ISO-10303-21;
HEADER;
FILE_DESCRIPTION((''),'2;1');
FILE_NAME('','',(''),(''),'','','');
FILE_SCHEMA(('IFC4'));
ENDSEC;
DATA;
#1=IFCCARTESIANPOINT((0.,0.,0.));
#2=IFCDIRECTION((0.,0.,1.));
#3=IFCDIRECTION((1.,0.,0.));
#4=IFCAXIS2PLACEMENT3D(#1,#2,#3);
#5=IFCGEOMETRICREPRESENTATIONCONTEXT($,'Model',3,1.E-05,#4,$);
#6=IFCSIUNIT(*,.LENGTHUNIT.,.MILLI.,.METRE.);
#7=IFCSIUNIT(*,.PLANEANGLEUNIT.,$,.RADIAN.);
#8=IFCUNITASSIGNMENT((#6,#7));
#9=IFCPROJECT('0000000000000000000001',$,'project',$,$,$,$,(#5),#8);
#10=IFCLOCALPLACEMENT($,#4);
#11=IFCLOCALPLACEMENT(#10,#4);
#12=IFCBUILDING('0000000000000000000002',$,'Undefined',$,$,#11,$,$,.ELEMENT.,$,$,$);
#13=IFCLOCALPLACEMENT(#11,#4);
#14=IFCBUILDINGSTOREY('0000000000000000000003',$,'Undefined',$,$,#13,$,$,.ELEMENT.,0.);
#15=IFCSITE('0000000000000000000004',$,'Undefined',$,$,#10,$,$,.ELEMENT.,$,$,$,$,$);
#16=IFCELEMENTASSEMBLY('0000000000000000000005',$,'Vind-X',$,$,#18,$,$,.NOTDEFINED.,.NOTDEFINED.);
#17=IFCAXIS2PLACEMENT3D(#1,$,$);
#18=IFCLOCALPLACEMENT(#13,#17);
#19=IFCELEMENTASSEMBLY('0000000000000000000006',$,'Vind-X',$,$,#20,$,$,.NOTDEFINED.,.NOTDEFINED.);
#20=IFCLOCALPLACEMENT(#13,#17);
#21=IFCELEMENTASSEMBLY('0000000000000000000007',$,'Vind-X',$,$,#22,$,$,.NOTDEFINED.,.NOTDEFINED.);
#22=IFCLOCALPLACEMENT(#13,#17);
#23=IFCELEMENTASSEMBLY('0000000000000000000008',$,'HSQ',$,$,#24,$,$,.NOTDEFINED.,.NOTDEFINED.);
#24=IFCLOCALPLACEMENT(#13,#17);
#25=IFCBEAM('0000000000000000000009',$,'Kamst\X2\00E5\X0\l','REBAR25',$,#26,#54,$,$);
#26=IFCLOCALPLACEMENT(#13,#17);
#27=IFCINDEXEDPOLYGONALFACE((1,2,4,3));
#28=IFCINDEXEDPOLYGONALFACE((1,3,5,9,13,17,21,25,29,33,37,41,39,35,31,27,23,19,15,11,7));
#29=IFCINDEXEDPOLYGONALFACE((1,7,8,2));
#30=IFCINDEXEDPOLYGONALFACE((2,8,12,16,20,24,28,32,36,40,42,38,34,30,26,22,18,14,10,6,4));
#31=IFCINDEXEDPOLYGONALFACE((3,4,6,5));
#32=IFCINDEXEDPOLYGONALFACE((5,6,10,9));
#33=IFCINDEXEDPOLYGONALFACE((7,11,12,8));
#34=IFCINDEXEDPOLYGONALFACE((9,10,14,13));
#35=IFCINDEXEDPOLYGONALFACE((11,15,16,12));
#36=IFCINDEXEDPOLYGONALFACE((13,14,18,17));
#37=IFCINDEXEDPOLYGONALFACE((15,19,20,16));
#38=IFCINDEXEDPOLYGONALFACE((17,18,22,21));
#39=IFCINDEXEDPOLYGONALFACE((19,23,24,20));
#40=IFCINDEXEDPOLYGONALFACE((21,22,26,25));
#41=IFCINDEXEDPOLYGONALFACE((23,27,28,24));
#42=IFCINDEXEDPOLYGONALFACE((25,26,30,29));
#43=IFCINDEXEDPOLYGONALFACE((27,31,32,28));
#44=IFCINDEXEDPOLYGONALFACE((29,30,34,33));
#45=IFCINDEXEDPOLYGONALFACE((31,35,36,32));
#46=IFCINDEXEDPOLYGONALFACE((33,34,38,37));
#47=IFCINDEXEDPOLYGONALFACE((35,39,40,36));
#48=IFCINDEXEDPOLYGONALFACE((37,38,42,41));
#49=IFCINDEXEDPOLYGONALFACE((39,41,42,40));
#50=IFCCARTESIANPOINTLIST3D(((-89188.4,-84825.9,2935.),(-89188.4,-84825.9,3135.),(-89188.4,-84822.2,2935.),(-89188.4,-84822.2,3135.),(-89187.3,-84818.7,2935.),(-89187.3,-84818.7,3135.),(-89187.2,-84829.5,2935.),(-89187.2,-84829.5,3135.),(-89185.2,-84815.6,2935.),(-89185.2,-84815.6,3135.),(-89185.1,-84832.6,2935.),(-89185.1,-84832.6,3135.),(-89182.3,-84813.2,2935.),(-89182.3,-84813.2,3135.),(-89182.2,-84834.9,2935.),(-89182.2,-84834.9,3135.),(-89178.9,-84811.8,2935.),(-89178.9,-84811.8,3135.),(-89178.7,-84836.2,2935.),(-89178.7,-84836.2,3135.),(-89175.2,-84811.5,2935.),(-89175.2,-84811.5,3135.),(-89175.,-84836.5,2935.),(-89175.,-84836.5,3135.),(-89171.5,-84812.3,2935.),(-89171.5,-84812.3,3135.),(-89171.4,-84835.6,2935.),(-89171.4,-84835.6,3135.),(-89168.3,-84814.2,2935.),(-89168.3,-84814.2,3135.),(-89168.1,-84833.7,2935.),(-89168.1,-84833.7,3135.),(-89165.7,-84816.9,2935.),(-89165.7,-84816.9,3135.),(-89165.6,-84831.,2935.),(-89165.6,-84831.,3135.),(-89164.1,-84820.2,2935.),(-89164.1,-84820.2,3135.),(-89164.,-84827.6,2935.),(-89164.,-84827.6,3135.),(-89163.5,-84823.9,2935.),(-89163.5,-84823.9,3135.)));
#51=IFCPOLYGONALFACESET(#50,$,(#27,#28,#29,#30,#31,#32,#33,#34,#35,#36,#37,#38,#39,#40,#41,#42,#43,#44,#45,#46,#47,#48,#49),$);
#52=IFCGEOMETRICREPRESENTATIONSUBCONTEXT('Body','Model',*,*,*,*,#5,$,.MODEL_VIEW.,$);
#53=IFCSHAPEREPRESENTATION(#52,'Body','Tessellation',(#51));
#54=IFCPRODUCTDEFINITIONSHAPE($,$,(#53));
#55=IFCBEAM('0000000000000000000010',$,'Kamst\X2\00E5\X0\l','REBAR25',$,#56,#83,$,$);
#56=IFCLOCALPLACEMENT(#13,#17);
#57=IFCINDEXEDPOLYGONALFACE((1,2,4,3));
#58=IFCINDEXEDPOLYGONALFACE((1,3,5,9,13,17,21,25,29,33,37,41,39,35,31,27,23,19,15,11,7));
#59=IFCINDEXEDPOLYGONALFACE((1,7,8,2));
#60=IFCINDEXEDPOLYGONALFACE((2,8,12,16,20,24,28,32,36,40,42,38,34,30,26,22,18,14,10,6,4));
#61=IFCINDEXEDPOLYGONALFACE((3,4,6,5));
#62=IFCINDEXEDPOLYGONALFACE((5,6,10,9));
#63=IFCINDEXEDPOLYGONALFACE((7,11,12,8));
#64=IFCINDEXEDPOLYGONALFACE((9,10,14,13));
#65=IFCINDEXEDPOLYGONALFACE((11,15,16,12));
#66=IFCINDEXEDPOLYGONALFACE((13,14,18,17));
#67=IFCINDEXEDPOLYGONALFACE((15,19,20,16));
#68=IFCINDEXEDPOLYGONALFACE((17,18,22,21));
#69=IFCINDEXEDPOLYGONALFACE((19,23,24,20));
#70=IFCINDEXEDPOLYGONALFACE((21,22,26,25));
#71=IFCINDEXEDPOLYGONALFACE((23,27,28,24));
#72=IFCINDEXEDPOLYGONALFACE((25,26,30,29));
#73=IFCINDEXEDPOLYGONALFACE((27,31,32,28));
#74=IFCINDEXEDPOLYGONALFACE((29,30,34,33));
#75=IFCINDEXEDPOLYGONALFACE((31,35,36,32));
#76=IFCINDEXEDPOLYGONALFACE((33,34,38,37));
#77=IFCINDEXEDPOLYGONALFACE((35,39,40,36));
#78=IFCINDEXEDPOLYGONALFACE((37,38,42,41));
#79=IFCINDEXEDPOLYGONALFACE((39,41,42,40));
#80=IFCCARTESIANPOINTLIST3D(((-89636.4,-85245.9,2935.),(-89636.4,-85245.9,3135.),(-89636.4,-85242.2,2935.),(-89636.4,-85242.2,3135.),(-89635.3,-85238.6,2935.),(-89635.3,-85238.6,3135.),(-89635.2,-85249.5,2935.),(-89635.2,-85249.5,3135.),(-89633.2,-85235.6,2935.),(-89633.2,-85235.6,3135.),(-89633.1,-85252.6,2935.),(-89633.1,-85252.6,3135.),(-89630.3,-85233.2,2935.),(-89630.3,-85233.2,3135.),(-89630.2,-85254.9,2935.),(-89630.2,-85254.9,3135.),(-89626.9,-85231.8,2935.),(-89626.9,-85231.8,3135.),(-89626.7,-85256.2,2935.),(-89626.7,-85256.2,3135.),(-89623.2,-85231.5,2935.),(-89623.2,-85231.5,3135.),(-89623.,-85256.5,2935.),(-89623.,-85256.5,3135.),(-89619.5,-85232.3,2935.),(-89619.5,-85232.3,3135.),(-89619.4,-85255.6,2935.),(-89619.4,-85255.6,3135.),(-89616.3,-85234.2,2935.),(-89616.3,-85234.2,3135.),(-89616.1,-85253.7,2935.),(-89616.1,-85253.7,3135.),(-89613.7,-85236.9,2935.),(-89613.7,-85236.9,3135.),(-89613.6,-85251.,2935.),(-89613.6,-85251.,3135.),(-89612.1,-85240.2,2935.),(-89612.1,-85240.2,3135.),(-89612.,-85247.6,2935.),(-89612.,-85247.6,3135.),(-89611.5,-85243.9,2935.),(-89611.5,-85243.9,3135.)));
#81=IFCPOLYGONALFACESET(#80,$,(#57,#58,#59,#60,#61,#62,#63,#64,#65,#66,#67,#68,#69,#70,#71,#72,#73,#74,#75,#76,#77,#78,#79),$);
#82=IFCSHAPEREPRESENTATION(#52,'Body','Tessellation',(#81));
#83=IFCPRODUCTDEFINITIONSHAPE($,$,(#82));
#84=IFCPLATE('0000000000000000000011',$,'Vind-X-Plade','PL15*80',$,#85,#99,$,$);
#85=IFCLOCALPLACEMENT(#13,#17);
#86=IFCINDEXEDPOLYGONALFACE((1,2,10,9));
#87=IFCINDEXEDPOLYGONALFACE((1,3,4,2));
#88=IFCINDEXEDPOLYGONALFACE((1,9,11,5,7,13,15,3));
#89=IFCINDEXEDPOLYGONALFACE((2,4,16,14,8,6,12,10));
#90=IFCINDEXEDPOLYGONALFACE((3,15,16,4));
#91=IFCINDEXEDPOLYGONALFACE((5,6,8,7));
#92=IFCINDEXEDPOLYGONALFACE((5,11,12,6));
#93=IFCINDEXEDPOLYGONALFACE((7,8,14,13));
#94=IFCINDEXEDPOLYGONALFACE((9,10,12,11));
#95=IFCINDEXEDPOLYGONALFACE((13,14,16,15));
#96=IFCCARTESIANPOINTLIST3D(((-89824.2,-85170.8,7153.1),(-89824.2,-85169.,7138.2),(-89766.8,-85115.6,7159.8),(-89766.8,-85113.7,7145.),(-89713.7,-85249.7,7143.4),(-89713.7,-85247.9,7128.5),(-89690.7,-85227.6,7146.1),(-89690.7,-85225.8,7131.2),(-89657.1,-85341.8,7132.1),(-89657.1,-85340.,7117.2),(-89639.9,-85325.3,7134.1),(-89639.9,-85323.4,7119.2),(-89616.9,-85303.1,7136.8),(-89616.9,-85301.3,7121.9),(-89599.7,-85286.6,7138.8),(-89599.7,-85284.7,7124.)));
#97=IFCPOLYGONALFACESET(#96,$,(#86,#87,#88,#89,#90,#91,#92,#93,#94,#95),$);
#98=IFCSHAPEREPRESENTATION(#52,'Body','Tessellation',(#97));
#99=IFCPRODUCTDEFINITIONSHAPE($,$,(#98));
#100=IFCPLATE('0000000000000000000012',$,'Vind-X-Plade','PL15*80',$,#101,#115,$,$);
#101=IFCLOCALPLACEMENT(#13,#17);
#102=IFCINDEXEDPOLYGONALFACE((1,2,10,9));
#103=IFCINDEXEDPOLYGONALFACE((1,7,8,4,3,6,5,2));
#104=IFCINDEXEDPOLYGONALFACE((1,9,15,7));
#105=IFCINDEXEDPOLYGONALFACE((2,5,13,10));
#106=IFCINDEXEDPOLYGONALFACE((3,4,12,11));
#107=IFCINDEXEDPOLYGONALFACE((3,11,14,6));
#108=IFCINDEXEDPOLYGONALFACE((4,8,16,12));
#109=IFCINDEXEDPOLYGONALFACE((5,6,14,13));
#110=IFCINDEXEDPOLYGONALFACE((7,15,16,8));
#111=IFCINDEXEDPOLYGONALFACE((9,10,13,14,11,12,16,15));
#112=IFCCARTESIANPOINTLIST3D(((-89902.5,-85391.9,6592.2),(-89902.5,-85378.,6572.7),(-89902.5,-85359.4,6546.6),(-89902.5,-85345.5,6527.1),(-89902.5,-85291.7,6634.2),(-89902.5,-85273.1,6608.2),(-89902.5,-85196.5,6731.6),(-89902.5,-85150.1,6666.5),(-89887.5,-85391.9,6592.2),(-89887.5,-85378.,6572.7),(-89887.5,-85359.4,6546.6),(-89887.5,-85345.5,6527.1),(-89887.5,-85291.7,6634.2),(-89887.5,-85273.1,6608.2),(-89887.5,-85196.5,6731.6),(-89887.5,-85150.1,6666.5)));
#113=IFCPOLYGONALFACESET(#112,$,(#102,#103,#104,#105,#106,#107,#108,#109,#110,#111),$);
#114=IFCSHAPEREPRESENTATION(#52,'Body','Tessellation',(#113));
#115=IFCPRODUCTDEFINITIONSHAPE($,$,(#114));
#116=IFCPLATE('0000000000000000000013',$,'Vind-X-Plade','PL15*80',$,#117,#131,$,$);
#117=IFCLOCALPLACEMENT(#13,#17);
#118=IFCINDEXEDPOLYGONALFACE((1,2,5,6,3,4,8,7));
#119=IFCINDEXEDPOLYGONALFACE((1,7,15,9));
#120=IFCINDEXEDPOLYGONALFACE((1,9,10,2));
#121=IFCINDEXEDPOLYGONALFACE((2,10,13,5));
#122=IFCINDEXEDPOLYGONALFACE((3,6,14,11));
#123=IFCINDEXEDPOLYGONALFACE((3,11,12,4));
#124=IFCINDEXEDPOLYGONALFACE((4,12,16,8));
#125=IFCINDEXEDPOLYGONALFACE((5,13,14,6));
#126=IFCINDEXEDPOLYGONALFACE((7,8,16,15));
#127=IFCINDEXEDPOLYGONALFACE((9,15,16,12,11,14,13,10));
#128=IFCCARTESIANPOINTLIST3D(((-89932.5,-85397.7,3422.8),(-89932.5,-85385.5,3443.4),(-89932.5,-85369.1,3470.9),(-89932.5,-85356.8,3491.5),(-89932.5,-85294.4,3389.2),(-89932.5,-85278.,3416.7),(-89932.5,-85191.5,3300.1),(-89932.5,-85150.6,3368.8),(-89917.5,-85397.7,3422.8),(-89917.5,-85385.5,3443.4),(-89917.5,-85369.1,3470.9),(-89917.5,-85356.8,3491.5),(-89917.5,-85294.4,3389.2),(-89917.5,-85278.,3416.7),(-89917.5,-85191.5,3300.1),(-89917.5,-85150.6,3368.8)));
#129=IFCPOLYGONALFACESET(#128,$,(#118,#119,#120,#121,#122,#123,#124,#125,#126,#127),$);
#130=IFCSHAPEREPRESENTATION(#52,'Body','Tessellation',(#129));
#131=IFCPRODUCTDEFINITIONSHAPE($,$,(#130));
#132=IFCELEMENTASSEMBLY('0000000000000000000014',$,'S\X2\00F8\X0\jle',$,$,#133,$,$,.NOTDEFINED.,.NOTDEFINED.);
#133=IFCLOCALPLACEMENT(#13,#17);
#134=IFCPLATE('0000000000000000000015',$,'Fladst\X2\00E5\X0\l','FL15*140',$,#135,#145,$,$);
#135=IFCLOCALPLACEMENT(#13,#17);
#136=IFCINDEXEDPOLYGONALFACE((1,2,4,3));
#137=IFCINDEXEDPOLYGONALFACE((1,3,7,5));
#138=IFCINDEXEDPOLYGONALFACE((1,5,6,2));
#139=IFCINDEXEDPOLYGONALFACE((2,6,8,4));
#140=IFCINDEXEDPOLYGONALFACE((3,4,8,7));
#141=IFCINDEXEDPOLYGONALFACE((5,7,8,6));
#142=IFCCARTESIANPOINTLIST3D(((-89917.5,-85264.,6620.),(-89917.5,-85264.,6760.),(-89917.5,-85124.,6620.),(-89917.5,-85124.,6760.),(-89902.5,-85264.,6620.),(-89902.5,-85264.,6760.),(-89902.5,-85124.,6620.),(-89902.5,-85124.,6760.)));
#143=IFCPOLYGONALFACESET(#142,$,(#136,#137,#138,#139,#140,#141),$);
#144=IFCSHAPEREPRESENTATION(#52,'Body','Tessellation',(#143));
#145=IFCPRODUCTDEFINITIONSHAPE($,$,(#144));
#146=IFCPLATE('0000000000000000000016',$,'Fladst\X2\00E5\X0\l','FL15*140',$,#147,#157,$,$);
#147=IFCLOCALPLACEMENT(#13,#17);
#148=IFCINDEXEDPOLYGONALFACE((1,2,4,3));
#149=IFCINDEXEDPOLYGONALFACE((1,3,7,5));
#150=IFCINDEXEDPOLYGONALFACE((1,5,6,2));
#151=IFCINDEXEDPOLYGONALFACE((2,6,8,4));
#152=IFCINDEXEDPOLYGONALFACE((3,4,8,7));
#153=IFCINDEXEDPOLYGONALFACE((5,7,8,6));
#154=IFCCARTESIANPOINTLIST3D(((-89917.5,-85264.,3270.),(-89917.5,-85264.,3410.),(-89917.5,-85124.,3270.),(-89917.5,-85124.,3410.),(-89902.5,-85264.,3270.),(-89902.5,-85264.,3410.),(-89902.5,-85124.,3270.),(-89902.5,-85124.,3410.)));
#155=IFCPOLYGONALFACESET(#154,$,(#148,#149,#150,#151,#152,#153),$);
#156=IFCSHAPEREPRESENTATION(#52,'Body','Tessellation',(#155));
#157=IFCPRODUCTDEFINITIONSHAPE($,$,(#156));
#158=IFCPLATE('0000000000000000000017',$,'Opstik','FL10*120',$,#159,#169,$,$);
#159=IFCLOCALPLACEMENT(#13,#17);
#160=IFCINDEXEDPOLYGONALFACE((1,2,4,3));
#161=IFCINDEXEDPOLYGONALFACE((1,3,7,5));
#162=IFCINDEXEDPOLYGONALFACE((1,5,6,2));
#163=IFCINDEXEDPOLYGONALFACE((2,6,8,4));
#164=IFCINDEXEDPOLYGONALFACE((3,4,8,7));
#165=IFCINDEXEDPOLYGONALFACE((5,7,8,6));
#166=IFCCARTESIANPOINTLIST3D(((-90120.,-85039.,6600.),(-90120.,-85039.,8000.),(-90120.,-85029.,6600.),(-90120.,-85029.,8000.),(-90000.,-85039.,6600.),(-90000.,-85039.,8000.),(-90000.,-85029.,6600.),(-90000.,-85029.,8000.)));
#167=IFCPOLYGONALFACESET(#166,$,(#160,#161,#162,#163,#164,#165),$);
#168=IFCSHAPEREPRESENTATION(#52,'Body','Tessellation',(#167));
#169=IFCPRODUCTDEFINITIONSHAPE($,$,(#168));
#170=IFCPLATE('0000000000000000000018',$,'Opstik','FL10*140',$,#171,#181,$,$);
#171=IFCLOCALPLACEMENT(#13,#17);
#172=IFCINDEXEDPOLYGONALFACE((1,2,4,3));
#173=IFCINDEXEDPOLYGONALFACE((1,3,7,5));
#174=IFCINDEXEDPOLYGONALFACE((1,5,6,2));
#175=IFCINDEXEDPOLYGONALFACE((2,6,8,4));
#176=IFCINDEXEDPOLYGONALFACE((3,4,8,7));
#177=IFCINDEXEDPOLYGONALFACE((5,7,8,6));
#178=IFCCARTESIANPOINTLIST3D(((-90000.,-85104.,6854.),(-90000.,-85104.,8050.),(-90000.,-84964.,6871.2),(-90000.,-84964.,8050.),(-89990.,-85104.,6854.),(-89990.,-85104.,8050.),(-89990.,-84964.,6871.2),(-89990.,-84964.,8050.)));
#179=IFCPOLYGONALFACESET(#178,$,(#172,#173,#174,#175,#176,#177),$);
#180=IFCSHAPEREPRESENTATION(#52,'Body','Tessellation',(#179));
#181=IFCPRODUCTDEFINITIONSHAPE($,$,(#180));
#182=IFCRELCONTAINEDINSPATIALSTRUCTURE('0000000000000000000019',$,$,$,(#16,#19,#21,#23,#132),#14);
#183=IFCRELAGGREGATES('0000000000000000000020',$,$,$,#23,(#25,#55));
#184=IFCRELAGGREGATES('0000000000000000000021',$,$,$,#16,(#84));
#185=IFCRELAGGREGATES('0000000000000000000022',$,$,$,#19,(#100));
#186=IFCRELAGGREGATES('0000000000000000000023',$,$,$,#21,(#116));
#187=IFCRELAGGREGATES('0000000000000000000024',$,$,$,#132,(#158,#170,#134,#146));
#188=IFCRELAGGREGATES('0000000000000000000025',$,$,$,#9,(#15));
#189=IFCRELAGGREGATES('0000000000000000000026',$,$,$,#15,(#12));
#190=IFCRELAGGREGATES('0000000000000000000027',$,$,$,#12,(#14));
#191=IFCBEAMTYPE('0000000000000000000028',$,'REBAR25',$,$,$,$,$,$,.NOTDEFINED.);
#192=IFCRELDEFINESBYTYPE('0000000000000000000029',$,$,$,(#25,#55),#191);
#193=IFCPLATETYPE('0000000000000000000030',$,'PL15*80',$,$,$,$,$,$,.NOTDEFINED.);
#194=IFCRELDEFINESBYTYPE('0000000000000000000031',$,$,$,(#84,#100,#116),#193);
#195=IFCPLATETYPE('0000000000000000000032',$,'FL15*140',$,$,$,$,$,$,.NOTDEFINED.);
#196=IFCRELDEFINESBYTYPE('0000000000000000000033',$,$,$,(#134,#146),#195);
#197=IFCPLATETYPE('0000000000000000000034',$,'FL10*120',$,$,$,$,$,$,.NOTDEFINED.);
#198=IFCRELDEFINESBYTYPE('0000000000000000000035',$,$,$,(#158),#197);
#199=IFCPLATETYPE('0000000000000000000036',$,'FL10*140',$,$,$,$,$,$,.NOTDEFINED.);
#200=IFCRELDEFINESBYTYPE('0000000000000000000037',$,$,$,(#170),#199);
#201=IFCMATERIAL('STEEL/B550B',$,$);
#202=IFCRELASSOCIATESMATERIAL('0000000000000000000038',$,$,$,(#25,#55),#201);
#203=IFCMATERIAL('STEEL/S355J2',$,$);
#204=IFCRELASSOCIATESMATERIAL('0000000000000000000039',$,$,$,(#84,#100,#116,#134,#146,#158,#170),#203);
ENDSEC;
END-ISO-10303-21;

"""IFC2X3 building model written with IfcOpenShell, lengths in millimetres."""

from ifc_helpers import new_model, si_unit, frame, origin_with_axes, origin_2d_with_axis, place, context, subcontext, project, spatial, polyline, circle, outline, extrude, boolean, material, type_object, element, aggregate, save


model = new_model("IFC2X3")

# Units and contexts
model_context = context("Model", 3, precision=1e-05, world=origin_with_axes())
body_context = subcontext(model_context, "Body", "Model", "MODEL_VIEW")
ifc_project = project(units=[si_unit("LENGTHUNIT", "METRE", prefix="MILLI"), si_unit("PLANEANGLEUNIT", "RADIAN")], contexts=[model_context])

# Site, building, storey
site_placement = place(None, origin_with_axes())
site = spatial("IfcSite", under=ifc_project, at=site_placement, Name="Undefined", CompositionType="ELEMENT")
building_placement = place(site_placement, origin_with_axes())
building = spatial("IfcBuilding", under=site, at=building_placement, Name="Undefined", CompositionType="ELEMENT")
storey_placement = place(building_placement, origin_with_axes())
storey = spatial("IfcBuildingStorey", under=building, at=storey_placement, Name="Undefined", CompositionType="ELEMENT", Elevation=0.0)

# Shared definitions
ifc_material_1 = material(Name="STEEL/S355J2")

# Element assembly
assembly_1_placement = place(storey_placement, origin_with_axes())
assembly_1 = element("IfcElementAssembly", 1, at=assembly_1_placement, inside=storey, Name="Vind-X", AssemblyPlace="NOTDEFINED", PredefinedType="NOTDEFINED")

# Element assemblies
assembly_2_placement = place(storey_placement, origin_with_axes())
assembly_2 = element("IfcElementAssembly", 2, at=assembly_2_placement, inside=storey, Name="Vind-X", AssemblyPlace="NOTDEFINED", PredefinedType="NOTDEFINED")
assembly_3_placement = place(storey_placement, origin_with_axes())
assembly_3 = element("IfcElementAssembly", 3, at=assembly_3_placement, inside=storey, Name="Vind-X", AssemblyPlace="NOTDEFINED", PredefinedType="NOTDEFINED")

# Element assembly, beams
assembly_4_placement = place(storey_placement, origin_with_axes())
assembly_4 = element("IfcElementAssembly", 4, at=assembly_4_placement, inside=storey, Name="HSQ", AssemblyPlace="NOTDEFINED", PredefinedType="NOTDEFINED")
ifc_material_2 = material(Name="STEEL/B550B")
beam_type_1 = type_object("IfcBeamType", Name="REBAR25", PredefinedType="NOTDEFINED")
beam_1_placement = place(assembly_4_placement, frame((-89176.0, -84824.0, 3135.0), z_axis=(-0.862746, -0.505638, 0.0), x_axis=(0.0, 0.0, -1.0)))
beam_1 = element("IfcBeam", 5, at=beam_1_placement, type_object=beam_type_1, material=ifc_material_2, Name="Kamstål", Description="REBAR25", context=body_context, shape_type="SweptSolid", body=[
    extrude(circle(Radius=12.5, at=origin_2d_with_axis()), frame((200.0, 0.0, 0.0), z_axis=(-1.0, 0.0, 0.0), x_axis=(0.0, -1.0, 0.0)), (0.0, 0.0, 1.0), 200.0),
])
beam_2_placement = place(assembly_4_placement, frame((-89624.0, -85244.0, 3135.0), z_axis=(-0.862746, -0.505638, 0.0), x_axis=(0.0, 0.0, -1.0)))
beam_2 = element("IfcBeam", 6, at=beam_2_placement, type_object=beam_type_1, material=ifc_material_2, Name="Kamstål", Description="REBAR25", context=body_context, shape_type="SweptSolid", body=[
    extrude(circle(Radius=12.5, at=origin_2d_with_axis()), frame((200.0, 0.0, 0.0), z_axis=(-1.0, 0.0, 0.0), x_axis=(0.0, -1.0, 0.0)), (0.0, 0.0, 1.0), 200.0),
])

# Plates
plate_type_1 = type_object("IfcPlateType", Name="PL15*80", PredefinedType="NOTDEFINED")
plate_1_placement = place(assembly_1_placement, frame((-89824.2, -85169.9, 7145.6), z_axis=(0.0, 0.121869, -0.992546), x_axis=(0.717842, 0.691017, 0.084846)))
plate_1 = element("IfcPlate", 7, at=plate_1_placement, type_object=plate_type_1, material=ifc_material_1, Name="Vind-X-Plade", Description="PL15*80", context=body_context, shape_type="CSG", body=[
    boolean("DIFFERENCE", extrude(outline(polyline([(0.0, 0.0), (80.0, 0.0), (80.0, 240.0), (0.0, 240.0), (0.0, 0.0)])), frame((0.0, 0.0, -7.5), z_axis=(0.0, 0.0, 1.0), x_axis=(1.0, 0.0, 0.0)), (0.0, 0.0, 1.0), 15.0), extrude(outline(polyline([(0.0, 0.0), (106.0, 0.0), (106.0, 32.0), (0.0, 32.0), (0.0, 0.0)])), frame((56.0, 240.0, 8.5), z_axis=(0.0, 0.0, -1.0), x_axis=(0.0, -1.0, 0.0)), (0.0, 0.0, 1.0), 17.0)),
])
plate_2_placement = place(assembly_2_placement, frame((-89895.0, -85150.1, 6666.5), z_axis=(1.0, 0.0, 0.0), x_axis=(0.0, -0.58074, 0.814089)))
plate_2 = element("IfcPlate", 8, at=plate_2_placement, type_object=plate_type_1, material=ifc_material_1, Name="Vind-X-Plade", Description="PL15*80", context=body_context, shape_type="CSG", body=[
    boolean("DIFFERENCE", extrude(outline(polyline([(0.0, 0.0), (80.0, 0.0), (80.0, 240.0), (0.0, 240.0), (0.0, 0.0)])), frame((0.0, 0.0, -7.5), z_axis=(0.0, 0.0, 1.0), x_axis=(1.0, 0.0, 0.0)), (0.0, 0.0, 1.0), 15.0), extrude(outline(polyline([(0.0, 0.0), (106.0, 0.0), (106.0, 32.0), (0.0, 32.0), (0.0, 0.0)])), frame((56.0, 240.0, 8.5), z_axis=(0.0, 0.0, -1.0), x_axis=(0.0, -1.0, 0.0)), (0.0, 0.0, 1.0), 17.0)),
])
plate_3_placement = place(assembly_3_placement, frame((-89925.0, -85191.5, 3300.1), z_axis=(1.0, 0.0, 0.0), x_axis=(0.0, 0.511223, 0.859448)))
plate_3 = element("IfcPlate", 9, at=plate_3_placement, type_object=plate_type_1, material=ifc_material_1, Name="Vind-X-Plade", Description="PL15*80", context=body_context, shape_type="CSG", body=[
    boolean("DIFFERENCE", extrude(outline(polyline([(0.0, 0.0), (80.0, 0.0), (80.0, 240.0), (0.0, 240.0), (0.0, 0.0)])), frame((0.0, 0.0, -7.5), z_axis=(0.0, 0.0, 1.0), x_axis=(1.0, 0.0, 0.0)), (0.0, 0.0, 1.0), 15.0), extrude(outline(polyline([(0.0, 0.0), (106.0, 0.0), (106.0, 32.0), (0.0, 32.0), (0.0, 0.0)])), frame((56.0, 240.0, 8.5), z_axis=(0.0, 0.0, -1.0), x_axis=(0.0, -1.0, 0.0)), (0.0, 0.0, 1.0), 17.0)),
])

# Element assembly, plates
assembly_5_placement = place(storey_placement, origin_with_axes())
assembly_5 = element("IfcElementAssembly", 10, at=assembly_5_placement, inside=storey, Name="Søjle", AssemblyPlace="NOTDEFINED", PredefinedType="NOTDEFINED")
plate_type_2 = type_object("IfcPlateType", Name="FL15*140", PredefinedType="NOTDEFINED")
plate_4_placement = place(assembly_5_placement, frame((-89910.0, -85124.0, 6620.0), z_axis=(-1.0, -0.000008, 0.0), x_axis=(0.000008, -1.0, 0.0)))
plate_4 = element("IfcPlate", 11, at=plate_4_placement, type_object=plate_type_2, material=ifc_material_1, Name="Fladstål", Description="FL15*140", context=body_context, shape_type="SweptSolid", body=[
    extrude(outline(polyline([(0.0, 0.0), (140.0, 0.0), (140.0, 140.0), (0.0, 140.0), (0.0, 0.0)])), frame((0.0, 0.0, -7.5), z_axis=(0.0, 0.0, 1.0), x_axis=(1.0, 0.0, 0.0)), (0.0, 0.0, 1.0), 15.0),
])
plate_5_placement = place(assembly_5_placement, frame((-89910.0, -85124.0, 3270.0), z_axis=(-1.0, -0.000008, 0.0), x_axis=(0.000008, -1.0, 0.0)))
plate_5 = element("IfcPlate", 12, at=plate_5_placement, type_object=plate_type_2, material=ifc_material_1, Name="Fladstål", Description="FL15*140", context=body_context, shape_type="SweptSolid", body=[
    extrude(outline(polyline([(0.0, 0.0), (140.0, 0.0), (140.0, 140.0), (0.0, 140.0), (0.0, 0.0)])), frame((0.0, 0.0, -7.5), z_axis=(0.0, 0.0, 1.0), x_axis=(1.0, 0.0, 0.0)), (0.0, 0.0, 1.0), 15.0),
])
plate_type_3 = type_object("IfcPlateType", Name="FL10*120", PredefinedType="NOTDEFINED")
plate_6_placement = place(assembly_5_placement, frame((-90000.0, -85034.0, 6600.0), z_axis=(0.0, -1.0, 0.0), x_axis=(0.0, 0.0, 1.0)))
plate_6 = element("IfcPlate", 13, at=plate_6_placement, type_object=plate_type_3, material=ifc_material_1, Name="Opstik", Description="FL10*120", context=body_context, shape_type="SweptSolid", body=[
    extrude(outline(polyline([(0.0, 0.0), (1400.0, 0.0), (1400.0, 120.0), (1400.0, 120.0), (0.0, 120.0), (0.0, 120.0), (0.0, 0.0)])), frame((0.0, 0.0, -5.0), z_axis=(0.0, 0.0, 1.0), x_axis=(1.0, 0.0, 0.0)), (0.0, 0.0, 1.0), 10.0),
])
plate_type_4 = type_object("IfcPlateType", Name="FL10*140", PredefinedType="NOTDEFINED")
plate_7_placement = place(assembly_5_placement, frame((-89995.0, -85104.0, 6854.0), z_axis=(-1.0, 0.0, 0.0), x_axis=(0.0, 0.0, 1.0)))
plate_7 = element("IfcPlate", 14, at=plate_7_placement, type_object=plate_type_4, material=ifc_material_1, Name="Opstik", Description="FL10*140", context=body_context, shape_type="SweptSolid", body=[
    extrude(outline(polyline([(0.0, 0.0), (1196.0, 0.0), (1196.0, 0.0), (1196.0, 140.0), (1196.0, 140.0), (17.2, 140.0), (0.0, 0.0)])), frame((0.0, 0.0, -5.0), z_axis=(0.0, 0.0, 1.0), x_axis=(1.0, 0.0, 0.0)), (0.0, 0.0, 1.0), 10.0),
])

aggregate(assembly_4, [beam_1, beam_2])

aggregate(assembly_1, [plate_1])
aggregate(assembly_2, [plate_2])
aggregate(assembly_3, [plate_3])
aggregate(assembly_5, [plate_6, plate_7, plate_4, plate_5])

save(model, "model.ifc")
